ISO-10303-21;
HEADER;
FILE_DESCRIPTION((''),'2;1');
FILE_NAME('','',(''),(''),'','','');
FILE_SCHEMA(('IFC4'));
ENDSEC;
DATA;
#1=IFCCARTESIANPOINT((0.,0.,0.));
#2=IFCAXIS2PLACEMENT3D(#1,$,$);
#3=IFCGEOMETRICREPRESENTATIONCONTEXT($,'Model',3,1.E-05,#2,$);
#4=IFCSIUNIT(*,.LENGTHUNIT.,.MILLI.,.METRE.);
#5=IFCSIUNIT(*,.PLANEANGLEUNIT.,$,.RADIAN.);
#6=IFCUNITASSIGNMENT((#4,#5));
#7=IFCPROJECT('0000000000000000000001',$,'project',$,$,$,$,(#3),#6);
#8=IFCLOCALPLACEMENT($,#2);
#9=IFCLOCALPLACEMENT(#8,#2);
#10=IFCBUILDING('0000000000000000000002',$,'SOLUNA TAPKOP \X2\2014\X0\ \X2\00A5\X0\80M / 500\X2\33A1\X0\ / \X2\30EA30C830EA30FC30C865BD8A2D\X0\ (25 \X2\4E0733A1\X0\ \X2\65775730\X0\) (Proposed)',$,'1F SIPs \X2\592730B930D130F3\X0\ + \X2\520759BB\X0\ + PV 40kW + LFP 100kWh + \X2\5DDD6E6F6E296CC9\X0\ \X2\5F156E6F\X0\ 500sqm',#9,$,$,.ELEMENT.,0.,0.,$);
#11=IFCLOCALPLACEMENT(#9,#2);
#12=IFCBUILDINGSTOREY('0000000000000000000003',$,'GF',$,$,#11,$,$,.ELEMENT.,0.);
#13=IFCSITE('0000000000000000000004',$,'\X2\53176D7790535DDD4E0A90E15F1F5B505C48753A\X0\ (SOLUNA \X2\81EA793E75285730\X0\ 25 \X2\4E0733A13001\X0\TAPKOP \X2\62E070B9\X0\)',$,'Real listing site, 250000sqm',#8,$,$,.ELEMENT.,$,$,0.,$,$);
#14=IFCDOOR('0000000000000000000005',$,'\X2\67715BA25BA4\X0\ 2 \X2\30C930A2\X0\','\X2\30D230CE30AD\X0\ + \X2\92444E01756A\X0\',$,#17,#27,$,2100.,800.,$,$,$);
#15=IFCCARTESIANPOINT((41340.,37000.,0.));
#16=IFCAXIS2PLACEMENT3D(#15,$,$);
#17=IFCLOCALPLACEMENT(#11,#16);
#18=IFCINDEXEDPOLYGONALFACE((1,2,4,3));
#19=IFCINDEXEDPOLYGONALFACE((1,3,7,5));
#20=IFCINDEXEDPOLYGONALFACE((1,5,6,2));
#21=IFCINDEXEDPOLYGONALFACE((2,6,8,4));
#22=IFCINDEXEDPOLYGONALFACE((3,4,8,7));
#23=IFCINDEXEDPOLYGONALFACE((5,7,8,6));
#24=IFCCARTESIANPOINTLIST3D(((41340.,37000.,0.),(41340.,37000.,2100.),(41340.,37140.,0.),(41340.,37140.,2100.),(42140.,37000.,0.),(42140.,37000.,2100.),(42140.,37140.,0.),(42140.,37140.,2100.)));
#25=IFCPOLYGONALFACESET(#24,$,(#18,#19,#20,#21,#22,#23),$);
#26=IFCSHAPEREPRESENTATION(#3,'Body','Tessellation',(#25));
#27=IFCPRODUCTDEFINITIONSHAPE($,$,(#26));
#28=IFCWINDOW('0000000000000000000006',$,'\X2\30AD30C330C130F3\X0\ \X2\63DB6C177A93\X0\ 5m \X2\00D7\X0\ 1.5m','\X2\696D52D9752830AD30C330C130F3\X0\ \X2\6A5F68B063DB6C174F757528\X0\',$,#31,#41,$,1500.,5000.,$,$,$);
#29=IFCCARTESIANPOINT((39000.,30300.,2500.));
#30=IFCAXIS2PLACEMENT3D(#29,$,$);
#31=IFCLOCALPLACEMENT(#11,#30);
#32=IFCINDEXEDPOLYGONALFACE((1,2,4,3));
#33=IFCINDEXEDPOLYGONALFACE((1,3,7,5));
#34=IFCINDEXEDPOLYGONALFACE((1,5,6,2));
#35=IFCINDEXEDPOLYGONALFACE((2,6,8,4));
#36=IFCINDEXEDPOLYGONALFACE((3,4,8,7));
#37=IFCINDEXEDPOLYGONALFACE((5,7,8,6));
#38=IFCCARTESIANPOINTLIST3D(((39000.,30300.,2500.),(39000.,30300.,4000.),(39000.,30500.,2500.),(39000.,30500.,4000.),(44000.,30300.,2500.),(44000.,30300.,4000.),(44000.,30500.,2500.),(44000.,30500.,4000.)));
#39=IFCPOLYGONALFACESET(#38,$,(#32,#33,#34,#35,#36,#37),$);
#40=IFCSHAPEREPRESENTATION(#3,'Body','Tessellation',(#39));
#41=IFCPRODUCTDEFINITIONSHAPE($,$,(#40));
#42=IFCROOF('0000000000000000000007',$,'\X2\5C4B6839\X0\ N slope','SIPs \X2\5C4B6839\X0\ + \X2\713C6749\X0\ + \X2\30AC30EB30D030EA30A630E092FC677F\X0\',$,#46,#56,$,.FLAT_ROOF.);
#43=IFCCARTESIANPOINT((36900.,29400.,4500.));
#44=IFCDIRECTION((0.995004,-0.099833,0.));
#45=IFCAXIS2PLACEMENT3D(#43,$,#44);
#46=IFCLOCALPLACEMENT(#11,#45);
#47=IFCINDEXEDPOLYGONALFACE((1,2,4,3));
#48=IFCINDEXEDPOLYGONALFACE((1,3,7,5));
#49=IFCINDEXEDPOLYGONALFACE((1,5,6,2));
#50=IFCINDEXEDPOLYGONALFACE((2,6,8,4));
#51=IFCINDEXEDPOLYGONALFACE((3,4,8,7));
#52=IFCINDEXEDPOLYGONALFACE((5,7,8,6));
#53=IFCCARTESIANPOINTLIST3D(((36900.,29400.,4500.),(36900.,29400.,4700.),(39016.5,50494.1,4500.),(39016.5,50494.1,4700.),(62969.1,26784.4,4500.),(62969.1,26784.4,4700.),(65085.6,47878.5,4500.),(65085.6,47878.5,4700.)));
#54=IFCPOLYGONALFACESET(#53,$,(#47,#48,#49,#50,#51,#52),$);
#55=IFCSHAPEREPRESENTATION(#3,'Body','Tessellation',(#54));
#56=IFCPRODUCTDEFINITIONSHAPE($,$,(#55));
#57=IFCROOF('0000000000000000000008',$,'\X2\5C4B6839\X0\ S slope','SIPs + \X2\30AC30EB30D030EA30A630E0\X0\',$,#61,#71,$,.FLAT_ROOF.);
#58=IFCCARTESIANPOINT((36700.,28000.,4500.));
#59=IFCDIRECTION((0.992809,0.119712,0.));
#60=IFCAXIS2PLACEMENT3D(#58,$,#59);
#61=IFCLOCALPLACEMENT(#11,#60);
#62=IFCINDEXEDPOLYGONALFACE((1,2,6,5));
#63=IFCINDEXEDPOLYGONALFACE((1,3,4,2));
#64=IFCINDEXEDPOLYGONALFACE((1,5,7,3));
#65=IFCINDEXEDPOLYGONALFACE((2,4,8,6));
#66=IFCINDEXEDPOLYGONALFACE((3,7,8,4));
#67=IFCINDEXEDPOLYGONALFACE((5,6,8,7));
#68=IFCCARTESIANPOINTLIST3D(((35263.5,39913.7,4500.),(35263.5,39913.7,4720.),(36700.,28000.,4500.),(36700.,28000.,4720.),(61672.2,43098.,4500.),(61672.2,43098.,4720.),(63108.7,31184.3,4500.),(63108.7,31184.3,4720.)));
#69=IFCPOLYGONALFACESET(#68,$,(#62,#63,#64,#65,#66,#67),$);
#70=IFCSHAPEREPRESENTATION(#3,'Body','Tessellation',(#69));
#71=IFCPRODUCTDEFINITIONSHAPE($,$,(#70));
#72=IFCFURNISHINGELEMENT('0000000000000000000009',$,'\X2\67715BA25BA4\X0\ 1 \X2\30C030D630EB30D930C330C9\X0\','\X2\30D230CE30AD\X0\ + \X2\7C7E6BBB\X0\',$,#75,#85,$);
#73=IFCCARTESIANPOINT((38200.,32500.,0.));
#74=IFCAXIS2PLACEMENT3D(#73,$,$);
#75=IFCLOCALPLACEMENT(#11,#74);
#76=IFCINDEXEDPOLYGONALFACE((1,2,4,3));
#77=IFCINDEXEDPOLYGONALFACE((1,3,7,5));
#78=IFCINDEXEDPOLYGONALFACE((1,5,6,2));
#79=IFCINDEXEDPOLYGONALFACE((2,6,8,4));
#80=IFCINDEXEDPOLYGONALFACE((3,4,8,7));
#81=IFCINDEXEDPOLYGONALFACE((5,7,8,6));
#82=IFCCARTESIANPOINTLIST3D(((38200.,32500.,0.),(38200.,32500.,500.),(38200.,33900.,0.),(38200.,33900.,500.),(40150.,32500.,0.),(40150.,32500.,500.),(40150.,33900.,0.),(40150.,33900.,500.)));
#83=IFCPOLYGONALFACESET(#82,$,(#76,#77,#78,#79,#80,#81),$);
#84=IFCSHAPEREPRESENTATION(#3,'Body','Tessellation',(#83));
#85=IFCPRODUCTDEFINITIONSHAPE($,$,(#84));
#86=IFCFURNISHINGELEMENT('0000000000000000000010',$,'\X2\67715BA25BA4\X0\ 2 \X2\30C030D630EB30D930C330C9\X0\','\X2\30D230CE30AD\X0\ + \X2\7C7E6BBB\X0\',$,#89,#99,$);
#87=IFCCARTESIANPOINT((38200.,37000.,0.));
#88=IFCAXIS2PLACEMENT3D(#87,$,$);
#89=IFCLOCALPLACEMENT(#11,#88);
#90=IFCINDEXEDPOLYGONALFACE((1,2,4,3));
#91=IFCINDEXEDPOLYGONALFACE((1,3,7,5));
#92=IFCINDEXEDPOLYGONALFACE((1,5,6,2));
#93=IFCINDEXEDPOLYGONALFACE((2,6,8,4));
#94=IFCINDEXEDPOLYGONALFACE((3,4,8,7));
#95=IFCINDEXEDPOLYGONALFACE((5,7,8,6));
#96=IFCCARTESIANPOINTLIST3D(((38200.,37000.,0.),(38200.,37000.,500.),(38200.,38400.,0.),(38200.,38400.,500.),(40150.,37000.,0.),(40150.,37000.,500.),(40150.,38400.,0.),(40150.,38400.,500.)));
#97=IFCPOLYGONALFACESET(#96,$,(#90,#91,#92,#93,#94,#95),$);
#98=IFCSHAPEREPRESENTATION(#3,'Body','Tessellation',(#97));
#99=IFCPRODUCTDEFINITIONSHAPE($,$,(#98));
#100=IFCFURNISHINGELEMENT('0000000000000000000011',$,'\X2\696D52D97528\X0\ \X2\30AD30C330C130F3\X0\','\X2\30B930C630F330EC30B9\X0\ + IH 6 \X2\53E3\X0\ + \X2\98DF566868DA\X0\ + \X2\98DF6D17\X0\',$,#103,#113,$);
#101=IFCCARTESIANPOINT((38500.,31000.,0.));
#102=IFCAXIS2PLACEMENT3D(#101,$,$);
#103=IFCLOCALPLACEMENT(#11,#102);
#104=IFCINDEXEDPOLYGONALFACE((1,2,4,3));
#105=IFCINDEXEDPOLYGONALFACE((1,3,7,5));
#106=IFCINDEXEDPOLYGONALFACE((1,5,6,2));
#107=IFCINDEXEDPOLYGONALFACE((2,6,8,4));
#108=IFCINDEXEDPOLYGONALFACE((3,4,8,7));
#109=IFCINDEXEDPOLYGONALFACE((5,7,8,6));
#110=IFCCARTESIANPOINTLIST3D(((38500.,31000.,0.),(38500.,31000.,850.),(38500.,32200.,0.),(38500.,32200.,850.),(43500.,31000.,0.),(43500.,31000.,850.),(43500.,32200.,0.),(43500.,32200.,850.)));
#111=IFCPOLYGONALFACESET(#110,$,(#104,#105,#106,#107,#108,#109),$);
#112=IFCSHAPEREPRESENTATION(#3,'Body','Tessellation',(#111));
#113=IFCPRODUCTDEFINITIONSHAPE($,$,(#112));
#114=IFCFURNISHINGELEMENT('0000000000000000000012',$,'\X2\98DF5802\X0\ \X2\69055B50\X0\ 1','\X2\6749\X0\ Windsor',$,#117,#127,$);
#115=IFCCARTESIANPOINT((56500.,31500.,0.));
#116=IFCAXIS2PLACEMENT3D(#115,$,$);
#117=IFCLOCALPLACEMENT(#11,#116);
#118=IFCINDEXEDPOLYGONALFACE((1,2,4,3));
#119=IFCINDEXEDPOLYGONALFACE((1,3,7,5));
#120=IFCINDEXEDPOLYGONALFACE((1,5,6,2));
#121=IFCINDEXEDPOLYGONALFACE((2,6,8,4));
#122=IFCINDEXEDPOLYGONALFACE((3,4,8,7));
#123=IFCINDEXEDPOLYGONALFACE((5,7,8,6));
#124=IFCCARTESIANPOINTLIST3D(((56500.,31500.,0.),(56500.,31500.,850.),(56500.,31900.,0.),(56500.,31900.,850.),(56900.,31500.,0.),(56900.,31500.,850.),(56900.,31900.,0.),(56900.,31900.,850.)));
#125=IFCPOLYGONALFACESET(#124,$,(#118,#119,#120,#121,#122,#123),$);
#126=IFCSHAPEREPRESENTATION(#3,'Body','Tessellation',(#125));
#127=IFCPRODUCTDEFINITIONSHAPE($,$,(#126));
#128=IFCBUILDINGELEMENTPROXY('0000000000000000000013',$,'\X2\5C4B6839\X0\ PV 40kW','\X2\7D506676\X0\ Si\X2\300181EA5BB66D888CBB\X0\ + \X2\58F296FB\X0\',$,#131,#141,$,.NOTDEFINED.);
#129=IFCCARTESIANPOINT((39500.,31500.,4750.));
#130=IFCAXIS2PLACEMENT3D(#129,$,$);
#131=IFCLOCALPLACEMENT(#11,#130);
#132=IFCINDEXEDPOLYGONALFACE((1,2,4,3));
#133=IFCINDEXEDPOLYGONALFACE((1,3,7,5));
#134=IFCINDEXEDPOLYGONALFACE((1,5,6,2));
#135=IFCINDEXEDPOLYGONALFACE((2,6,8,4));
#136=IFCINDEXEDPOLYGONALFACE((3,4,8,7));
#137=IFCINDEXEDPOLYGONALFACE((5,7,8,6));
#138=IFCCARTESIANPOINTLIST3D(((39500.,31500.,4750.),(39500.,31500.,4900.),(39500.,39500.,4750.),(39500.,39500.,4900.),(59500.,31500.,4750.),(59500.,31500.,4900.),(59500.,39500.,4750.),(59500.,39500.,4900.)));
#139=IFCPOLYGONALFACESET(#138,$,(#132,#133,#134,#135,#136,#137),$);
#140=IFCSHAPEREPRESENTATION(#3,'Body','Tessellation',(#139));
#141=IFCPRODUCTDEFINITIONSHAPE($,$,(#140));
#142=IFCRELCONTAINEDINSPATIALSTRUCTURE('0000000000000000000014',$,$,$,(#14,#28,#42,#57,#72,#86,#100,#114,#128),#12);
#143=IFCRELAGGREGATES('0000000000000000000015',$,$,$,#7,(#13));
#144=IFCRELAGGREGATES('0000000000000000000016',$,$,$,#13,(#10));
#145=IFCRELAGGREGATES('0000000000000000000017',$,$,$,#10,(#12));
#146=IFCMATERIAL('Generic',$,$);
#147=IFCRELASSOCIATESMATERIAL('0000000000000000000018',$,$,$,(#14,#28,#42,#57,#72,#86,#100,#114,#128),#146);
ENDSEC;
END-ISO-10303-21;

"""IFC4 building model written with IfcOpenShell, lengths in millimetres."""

from ifc_helpers import new_model, si_unit, frame, frame_2d, origin, place, context, project, spatial, rectangle, extrude, material, element, save


model = new_model("IFC4")

# Units and contexts
model_context = context("Model", 3, precision=1e-05, world=origin())
ifc_project = project(units=[si_unit("LENGTHUNIT", "METRE", prefix="MILLI"), si_unit("PLANEANGLEUNIT", "RADIAN")], contexts=[model_context])

# Site, building, storey
site_placement = place(None, origin())
site = spatial("IfcSite", under=ifc_project, at=site_placement, Name="北海道川上郡弟子屈町 (SOLUNA 自社用地 25 万㎡、TAPKOP 拠点)", ObjectType="Real listing site, 250000sqm", CompositionType="ELEMENT", RefElevation=0.0)
building_placement = place(site_placement, origin())
building = spatial("IfcBuilding", under=site, at=building_placement, Name="SOLUNA TAPKOP — ¥80M / 500㎡ / リトリート施設 (25 万㎡ 敷地) (Proposed)", ObjectType="1F SIPs 大スパン + 切妻 + PV 40kW + LFP 100kWh + 川湯温泉 引湯 500sqm", CompositionType="ELEMENT", ElevationOfRefHeight=0.0, ElevationOfTerrain=0.0)
storey_placement = place(building_placement, origin())
storey = spatial("IfcBuildingStorey", under=building, at=storey_placement, Name="GF", CompositionType="ELEMENT", Elevation=0.0)

# Shared definitions
ifc_material_1 = material(Name="Generic")

# Door
door_1_placement = place(storey_placement, frame((41340.0, 37000.0, 0.0)))
element("IfcDoor", 1, at=door_1_placement, inside=storey, material=ifc_material_1, Name="東客室 2 ドア", Description="ヒノキ + 鉄丁番", OverallHeight=2100.0, OverallWidth=800.0, context=model_context, shape_type="SweptSolid", body=[
    extrude(rectangle(XDim=800.0, YDim=140.0, at=frame_2d((400.0, 70.0))), frame((41340.0, 37000.0, 0.0)), (0.0, 0.0, 1.0), 2100.0),
])

# Window
window_1_placement = place(storey_placement, frame((39000.0, 30300.0, 2500.0)))
element("IfcWindow", 2, at=window_1_placement, inside=storey, material=ifc_material_1, Name="キッチン 換気窓 5m × 1.5m", Description="業務用キッチン 機械換気併用", OverallHeight=1500.0, OverallWidth=5000.0, context=model_context, shape_type="SweptSolid", body=[
    extrude(rectangle(XDim=5000.0, YDim=200.0, at=frame_2d((2500.0, 100.0))), frame((39000.0, 30300.0, 2500.0)), (0.0, 0.0, 1.0), 1500.0),
])

# Roofs
roof_1_placement = place(storey_placement, frame((36900.0, 29400.0, 4500.0), x_axis=(0.995004, -0.099833, 0.0)))
element("IfcRoof", 3, at=roof_1_placement, inside=storey, material=ifc_material_1, Name="屋根 N slope", Description="SIPs 屋根 + 焼杉 + ガルバリウム鋼板", PredefinedType="FLAT_ROOF", context=model_context, shape_type="SweptSolid", body=[
    extrude(rectangle(XDim=26200.0, YDim=21200.0, at=frame_2d((13100.0, 10600.0))), frame((36900.0, 29400.0, 4500.0), x_axis=(0.995004, -0.099833, 0.0)), (0.0, 0.0, 1.0), 200.0),
])
roof_2_placement = place(storey_placement, frame((36700.0, 28000.0, 4500.0), x_axis=(0.992809, 0.119712, 0.0)))
element("IfcRoof", 4, at=roof_2_placement, inside=storey, material=ifc_material_1, Name="屋根 S slope", Description="SIPs + ガルバリウム", PredefinedType="FLAT_ROOF", context=model_context, shape_type="SweptSolid", body=[
    extrude(rectangle(XDim=26600.0, YDim=12000.0, at=frame_2d((13300.0, 6000.0))), frame((36700.0, 28000.0, 4500.0), x_axis=(0.992809, 0.119712, 0.0)), (0.0, 0.0, 1.0), 220.0),
])

# Furnishing elements
furnishing_1_placement = place(storey_placement, frame((38200.0, 32500.0, 0.0)))
element("IfcFurnishingElement", 5, at=furnishing_1_placement, inside=storey, material=ifc_material_1, Name="東客室 1 ダブルベッド", Description="ヒノキ + 籾殻", context=model_context, shape_type="SweptSolid", body=[
    extrude(rectangle(XDim=1950.0, YDim=1400.0, at=frame_2d((975.0, 700.0))), frame((38200.0, 32500.0, 0.0)), (0.0, 0.0, 1.0), 500.0),
])
furnishing_2_placement = place(storey_placement, frame((38200.0, 37000.0, 0.0)))
element("IfcFurnishingElement", 6, at=furnishing_2_placement, inside=storey, material=ifc_material_1, Name="東客室 2 ダブルベッド", Description="ヒノキ + 籾殻", context=model_context, shape_type="SweptSolid", body=[
    extrude(rectangle(XDim=1950.0, YDim=1400.0, at=frame_2d((975.0, 700.0))), frame((38200.0, 37000.0, 0.0)), (0.0, 0.0, 1.0), 500.0),
])
furnishing_3_placement = place(storey_placement, frame((38500.0, 31000.0, 0.0)))
element("IfcFurnishingElement", 7, at=furnishing_3_placement, inside=storey, material=ifc_material_1, Name="業務用 キッチン", Description="ステンレス + IH 6 口 + 食器棚 + 食洗", context=model_context, shape_type="SweptSolid", body=[
    extrude(rectangle(XDim=5000.0, YDim=1200.0, at=frame_2d((2500.0, 600.0))), frame((38500.0, 31000.0, 0.0)), (0.0, 0.0, 1.0), 850.0),
])
furnishing_4_placement = place(storey_placement, frame((56500.0, 31500.0, 0.0)))
element("IfcFurnishingElement", 8, at=furnishing_4_placement, inside=storey, material=ifc_material_1, Name="食堂 椅子 1", Description="杉 Windsor", context=model_context, shape_type="SweptSolid", body=[
    extrude(rectangle(XDim=400.0, YDim=400.0, at=frame_2d((200.0, 200.0))), frame((56500.0, 31500.0, 0.0)), (0.0, 0.0, 1.0), 850.0),
])

# Building element proxy
proxy_placement = place(storey_placement, frame((39500.0, 31500.0, 4750.0)))
element("IfcBuildingElementProxy", 9, at=proxy_placement, inside=storey, material=ifc_material_1, Name="屋根 PV 40kW", Description="結晶 Si、自家消費 + 売電", PredefinedType="NOTDEFINED", context=model_context, shape_type="SweptSolid", body=[
    extrude(rectangle(XDim=20000.0, YDim=8000.0, at=frame_2d((10000.0, 4000.0))), frame((39500.0, 31500.0, 4750.0)), (0.0, 0.0, 1.0), 150.0),
])

save(model, "model.ifc")
